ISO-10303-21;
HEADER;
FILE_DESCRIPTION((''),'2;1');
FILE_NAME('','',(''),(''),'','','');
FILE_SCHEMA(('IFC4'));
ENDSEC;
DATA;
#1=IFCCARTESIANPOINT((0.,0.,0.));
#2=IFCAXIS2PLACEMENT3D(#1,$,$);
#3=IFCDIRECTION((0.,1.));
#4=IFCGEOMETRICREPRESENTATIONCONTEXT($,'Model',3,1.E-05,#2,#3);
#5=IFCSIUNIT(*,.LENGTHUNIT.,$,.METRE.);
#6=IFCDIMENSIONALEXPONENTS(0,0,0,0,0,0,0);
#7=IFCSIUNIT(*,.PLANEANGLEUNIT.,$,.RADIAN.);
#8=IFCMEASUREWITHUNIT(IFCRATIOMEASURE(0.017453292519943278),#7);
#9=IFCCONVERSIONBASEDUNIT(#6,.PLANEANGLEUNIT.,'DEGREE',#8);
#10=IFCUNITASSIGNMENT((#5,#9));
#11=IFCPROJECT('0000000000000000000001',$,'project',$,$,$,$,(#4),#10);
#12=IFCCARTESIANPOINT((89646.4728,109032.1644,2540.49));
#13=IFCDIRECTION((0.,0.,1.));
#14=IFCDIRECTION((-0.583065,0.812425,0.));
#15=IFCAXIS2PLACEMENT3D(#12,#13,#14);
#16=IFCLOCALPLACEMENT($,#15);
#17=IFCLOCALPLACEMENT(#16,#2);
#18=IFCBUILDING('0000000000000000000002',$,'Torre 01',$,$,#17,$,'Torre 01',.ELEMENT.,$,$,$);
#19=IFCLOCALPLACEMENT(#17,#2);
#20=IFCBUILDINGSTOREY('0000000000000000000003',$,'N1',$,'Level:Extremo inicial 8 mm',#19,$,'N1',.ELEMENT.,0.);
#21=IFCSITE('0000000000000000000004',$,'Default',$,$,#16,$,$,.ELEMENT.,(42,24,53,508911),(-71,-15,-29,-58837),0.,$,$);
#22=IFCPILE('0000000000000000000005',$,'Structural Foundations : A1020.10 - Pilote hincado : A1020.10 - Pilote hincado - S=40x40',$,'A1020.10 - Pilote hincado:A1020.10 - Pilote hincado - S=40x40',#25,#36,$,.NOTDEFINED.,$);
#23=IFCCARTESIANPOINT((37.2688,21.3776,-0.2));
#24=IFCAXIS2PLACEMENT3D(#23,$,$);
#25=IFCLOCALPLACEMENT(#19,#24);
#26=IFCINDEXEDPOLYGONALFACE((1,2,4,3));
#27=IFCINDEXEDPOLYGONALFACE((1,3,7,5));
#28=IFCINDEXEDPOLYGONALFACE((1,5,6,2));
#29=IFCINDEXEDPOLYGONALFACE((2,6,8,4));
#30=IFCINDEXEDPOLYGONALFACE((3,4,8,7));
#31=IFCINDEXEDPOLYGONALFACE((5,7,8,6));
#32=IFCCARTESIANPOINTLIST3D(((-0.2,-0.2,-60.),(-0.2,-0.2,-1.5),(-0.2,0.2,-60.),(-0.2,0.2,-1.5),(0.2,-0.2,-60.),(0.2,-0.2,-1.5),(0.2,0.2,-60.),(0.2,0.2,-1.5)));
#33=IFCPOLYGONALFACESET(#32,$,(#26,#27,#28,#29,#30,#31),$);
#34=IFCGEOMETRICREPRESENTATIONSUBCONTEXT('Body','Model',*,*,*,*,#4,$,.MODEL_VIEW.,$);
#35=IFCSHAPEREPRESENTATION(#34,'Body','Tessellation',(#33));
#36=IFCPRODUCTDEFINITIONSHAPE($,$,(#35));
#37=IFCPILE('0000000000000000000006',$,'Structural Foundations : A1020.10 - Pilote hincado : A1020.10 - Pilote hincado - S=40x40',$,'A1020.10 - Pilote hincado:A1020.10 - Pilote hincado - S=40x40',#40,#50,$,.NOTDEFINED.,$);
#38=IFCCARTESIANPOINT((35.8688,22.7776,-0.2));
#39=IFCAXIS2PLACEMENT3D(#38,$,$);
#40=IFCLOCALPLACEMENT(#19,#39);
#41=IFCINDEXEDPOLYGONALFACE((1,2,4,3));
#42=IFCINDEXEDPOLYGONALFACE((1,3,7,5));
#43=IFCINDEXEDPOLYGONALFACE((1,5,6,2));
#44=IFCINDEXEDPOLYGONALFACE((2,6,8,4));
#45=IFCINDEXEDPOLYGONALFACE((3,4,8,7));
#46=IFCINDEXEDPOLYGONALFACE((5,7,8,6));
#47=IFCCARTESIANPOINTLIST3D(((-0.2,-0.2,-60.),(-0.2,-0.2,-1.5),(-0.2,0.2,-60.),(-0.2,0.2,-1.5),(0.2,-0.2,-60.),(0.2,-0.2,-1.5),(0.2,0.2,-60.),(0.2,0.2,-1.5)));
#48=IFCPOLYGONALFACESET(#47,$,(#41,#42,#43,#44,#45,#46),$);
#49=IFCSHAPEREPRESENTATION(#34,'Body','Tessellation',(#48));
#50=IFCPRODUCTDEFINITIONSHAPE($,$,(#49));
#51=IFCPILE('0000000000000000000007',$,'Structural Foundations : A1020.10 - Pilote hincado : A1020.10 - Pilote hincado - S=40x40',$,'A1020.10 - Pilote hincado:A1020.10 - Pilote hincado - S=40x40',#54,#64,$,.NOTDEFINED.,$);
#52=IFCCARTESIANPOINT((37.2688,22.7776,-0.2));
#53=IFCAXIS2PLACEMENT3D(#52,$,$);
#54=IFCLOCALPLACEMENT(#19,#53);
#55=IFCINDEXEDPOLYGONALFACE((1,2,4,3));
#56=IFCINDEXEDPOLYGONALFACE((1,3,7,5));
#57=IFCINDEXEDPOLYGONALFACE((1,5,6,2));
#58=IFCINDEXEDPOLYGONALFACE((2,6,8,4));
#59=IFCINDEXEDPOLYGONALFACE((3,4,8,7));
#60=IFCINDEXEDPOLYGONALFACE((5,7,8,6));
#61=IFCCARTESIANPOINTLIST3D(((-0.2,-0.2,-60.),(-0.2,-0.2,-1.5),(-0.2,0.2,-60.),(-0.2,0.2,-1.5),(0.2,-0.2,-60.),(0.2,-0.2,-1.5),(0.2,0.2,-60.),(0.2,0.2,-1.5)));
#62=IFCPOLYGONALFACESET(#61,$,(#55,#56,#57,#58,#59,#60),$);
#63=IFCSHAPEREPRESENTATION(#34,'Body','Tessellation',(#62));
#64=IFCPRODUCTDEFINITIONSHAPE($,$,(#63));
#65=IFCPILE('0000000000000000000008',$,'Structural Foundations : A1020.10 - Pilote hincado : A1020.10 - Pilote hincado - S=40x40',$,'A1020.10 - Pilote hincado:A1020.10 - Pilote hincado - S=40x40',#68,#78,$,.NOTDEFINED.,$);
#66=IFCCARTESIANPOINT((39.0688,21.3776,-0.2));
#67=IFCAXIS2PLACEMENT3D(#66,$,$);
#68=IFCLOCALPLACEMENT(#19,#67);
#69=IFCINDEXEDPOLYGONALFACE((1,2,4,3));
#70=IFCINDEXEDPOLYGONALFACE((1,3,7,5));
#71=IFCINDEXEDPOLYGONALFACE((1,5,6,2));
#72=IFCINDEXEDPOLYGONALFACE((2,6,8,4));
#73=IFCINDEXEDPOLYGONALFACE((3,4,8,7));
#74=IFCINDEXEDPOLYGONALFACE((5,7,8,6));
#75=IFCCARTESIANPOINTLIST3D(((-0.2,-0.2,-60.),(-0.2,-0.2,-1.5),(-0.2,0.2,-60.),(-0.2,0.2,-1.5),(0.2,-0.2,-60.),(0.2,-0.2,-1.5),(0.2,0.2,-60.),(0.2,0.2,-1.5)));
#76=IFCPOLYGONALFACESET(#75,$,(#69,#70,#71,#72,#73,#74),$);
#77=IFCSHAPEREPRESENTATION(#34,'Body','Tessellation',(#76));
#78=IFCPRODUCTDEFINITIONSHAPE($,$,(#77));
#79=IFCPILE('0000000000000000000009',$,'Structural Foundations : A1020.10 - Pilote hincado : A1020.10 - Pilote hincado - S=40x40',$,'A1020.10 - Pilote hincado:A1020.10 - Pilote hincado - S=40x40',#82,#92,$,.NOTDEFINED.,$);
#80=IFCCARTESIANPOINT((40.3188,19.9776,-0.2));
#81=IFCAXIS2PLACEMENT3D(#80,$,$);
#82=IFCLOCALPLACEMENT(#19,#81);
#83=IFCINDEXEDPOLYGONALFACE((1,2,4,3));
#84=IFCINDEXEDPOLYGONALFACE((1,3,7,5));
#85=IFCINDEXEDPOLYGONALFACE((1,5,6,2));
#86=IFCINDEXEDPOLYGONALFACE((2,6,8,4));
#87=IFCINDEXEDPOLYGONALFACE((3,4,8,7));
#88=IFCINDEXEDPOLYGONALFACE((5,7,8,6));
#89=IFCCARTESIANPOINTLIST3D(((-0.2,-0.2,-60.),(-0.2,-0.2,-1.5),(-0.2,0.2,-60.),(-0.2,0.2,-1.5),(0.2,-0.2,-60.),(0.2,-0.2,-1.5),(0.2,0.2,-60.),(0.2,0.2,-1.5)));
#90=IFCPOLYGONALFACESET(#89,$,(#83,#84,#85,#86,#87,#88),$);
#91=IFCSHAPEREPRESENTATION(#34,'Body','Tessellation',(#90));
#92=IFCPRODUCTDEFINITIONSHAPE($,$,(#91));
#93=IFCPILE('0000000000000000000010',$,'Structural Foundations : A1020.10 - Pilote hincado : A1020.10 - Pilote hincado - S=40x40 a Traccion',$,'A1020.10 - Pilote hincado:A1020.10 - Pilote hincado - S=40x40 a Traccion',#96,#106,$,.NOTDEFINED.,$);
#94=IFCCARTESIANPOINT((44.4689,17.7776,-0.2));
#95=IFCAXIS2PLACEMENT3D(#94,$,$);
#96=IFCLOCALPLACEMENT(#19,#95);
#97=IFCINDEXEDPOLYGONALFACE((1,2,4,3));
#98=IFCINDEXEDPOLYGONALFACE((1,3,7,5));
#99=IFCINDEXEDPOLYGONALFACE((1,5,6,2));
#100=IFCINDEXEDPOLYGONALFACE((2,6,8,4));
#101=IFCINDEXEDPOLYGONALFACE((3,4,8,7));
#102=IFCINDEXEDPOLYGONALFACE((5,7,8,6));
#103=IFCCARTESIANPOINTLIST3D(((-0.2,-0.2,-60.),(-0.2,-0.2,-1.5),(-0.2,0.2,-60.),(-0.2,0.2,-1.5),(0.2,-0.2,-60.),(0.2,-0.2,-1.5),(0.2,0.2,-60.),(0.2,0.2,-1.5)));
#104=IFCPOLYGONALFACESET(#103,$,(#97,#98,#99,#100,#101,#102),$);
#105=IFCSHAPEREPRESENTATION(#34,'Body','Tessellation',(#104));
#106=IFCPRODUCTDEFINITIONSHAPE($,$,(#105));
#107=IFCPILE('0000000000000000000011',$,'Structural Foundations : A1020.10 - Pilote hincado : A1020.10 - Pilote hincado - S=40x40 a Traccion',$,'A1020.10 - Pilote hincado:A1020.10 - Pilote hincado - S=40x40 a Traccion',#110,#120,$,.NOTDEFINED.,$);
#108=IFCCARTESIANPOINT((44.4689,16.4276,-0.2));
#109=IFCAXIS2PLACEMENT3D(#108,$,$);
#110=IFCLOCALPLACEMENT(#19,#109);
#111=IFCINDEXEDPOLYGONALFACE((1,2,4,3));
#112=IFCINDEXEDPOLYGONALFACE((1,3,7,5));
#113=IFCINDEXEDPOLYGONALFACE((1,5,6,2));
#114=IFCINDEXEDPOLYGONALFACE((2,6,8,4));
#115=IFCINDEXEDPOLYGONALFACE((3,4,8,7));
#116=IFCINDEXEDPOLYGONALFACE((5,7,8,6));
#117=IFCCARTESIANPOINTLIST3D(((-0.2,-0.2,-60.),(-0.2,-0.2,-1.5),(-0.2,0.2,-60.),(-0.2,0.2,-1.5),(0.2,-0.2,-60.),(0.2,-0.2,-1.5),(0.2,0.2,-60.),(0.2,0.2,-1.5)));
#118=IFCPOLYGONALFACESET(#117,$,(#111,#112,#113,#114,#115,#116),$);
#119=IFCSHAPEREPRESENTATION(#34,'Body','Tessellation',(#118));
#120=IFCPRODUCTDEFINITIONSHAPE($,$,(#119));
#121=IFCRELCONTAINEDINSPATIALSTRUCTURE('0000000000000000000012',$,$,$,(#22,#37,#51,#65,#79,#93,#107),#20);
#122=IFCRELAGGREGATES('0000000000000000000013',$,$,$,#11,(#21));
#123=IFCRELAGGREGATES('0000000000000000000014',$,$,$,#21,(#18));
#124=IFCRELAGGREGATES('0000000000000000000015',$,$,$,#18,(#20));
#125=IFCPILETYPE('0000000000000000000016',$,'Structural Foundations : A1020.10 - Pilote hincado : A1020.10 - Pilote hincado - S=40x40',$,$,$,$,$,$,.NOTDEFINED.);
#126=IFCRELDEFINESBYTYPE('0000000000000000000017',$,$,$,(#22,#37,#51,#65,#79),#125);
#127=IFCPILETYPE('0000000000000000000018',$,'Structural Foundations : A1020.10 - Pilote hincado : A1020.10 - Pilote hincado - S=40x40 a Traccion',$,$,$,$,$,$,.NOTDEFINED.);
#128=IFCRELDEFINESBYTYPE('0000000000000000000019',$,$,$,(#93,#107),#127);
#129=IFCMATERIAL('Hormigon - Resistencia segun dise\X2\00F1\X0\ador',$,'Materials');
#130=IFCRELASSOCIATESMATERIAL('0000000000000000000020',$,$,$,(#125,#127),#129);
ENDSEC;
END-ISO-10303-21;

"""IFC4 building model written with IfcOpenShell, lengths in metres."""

from ifc_helpers import new_model, entity, si_unit, converted_unit, direction, frame, origin, origin_2d_with_axis, place, context, subcontext, project, spatial, polyline, segment, composite_curve, rectangle, outline, extrude, source, transform, mapped, material, material_profile, profile_set, type_object, type_shapes, element, save


model = new_model("IFC4")

# Units and contexts
model_context = context("Model", 3, precision=1e-05, world=origin(), true_north=direction((0.0, 1.0)))
body_context = subcontext(model_context, "Body", "Model", "MODEL_VIEW")
ifc_project = project(units=[si_unit("LENGTHUNIT", "METRE"), converted_unit("PLANEANGLEUNIT", "DEGREE", entity("IfcRatioMeasure", 0.017453292519943278), si_unit("PLANEANGLEUNIT", "RADIAN"), dimensions=[0, 0, 0, 0, 0, 0, 0])], contexts=[model_context])

# Site, building, storey
site_placement = place(None, frame((89646.4728, 109032.1644, 2540.49), z_axis=(0.0, 0.0, 1.0), x_axis=(-0.583065, 0.812425, 0.0)))
site = spatial("IfcSite", under=ifc_project, at=site_placement, Name="Default", CompositionType="ELEMENT", RefLatitude=(42, 24, 53, 508911), RefLongitude=(-71, -15, -29, -58837), RefElevation=0.0)
building_placement = place(site_placement, origin())
building = spatial("IfcBuilding", under=site, at=building_placement, Name="Torre 01", LongName="Torre 01", CompositionType="ELEMENT")
storey_placement = place(building_placement, origin())
storey = spatial("IfcBuildingStorey", under=building, at=storey_placement, Name="N1", ObjectType="Level:Extremo inicial 8 mm", LongName="N1", CompositionType="ELEMENT", Elevation=0.0)

# Piles
ifc_material_1 = material(Name="Hormigon - Resistencia segun diseñador", Category="Materials")
ifc_material_profile_1 = material_profile(ifc_material_1, outline(composite_curve([segment(polyline([(0.2, -0.2, -60.0), (-0.2, -0.2, -60.0)]), True, "CONTINUOUS"), segment(polyline([(-0.2, -0.2, -60.0), (-0.2, 0.2, -60.0)]), True, "CONTINUOUS"), segment(polyline([(-0.2, 0.2, -60.0), (0.2, 0.2, -60.0)]), True, "CONTINUOUS"), segment(polyline([(0.2, 0.2, -60.0), (0.2, -0.2, -60.0)]), True, "CONTINUOUS")], self_intersect=False), kind="CURVE"), Name="A1020.10 - Pilote hincado - S=40x40")
ifc_profile_set_1 = profile_set([ifc_material_profile_1], Name="A1020.10 - Pilote hincado - S=40x40")
pile_type_1 = type_object("IfcPileType", Name="Structural Foundations : A1020.10 - Pilote hincado : A1020.10 - Pilote hincado - S=40x40", PredefinedType="NOTDEFINED", material=ifc_profile_set_1)
shared_shape_1 = source(origin(), body_context, "Body", "SweptSolid", [
    extrude(rectangle(XDim=0.4, YDim=0.4, at=origin_2d_with_axis()), frame((0.0, 0.0, -60.0), z_axis=(0.0, 0.0, 1.0), x_axis=(0.0, -1.0, 0.0)), (0.0, 0.0, 1.0), 58.5),
])
type_shapes(pile_type_1, [shared_shape_1])
for number, where, name in (
    (1, (37.2688, 21.3776, -0.2), "Structural Foundations : A1020.10 - Pilote hincado : A1020.10 - Pilote hincado - S=40x40"),
    (2, (35.8688, 22.7776, -0.2), "Structural Foundations : A1020.10 - Pilote hincado : A1020.10 - Pilote hincado - S=40x40"),
    (3, (37.2688, 22.7776, -0.2), "Structural Foundations : A1020.10 - Pilote hincado : A1020.10 - Pilote hincado - S=40x40"),
    (4, (39.0688, 21.3776, -0.2), "Structural Foundations : A1020.10 - Pilote hincado : A1020.10 - Pilote hincado - S=40x40"),
    (5, (40.3188, 19.9776, -0.2), "Structural Foundations : A1020.10 - Pilote hincado : A1020.10 - Pilote hincado - S=40x40"),
):
    element("IfcPile", number, at=place(storey_placement, frame(where)), inside=storey, type_object=pile_type_1, Name=name, ObjectType="A1020.10 - Pilote hincado:A1020.10 - Pilote hincado - S=40x40", PredefinedType="NOTDEFINED", context=body_context, shape_type="MappedRepresentation", body=[
        mapped(shared_shape_1, transform((0.0, 0.0, 0.0), scale=1.0)),
    ])
ifc_material_profile_2 = material_profile(ifc_material_1, outline(composite_curve([segment(polyline([(0.2, -0.2, -60.0), (-0.2, -0.2, -60.0)]), True, "CONTINUOUS"), segment(polyline([(-0.2, -0.2, -60.0), (-0.2, 0.2, -60.0)]), True, "CONTINUOUS"), segment(polyline([(-0.2, 0.2, -60.0), (0.2, 0.2, -60.0)]), True, "CONTINUOUS"), segment(polyline([(0.2, 0.2, -60.0), (0.2, -0.2, -60.0)]), True, "CONTINUOUS")], self_intersect=False), kind="CURVE"), Name="A1020.10 - Pilote hincado - S=40x40 a Traccion")
ifc_profile_set_2 = profile_set([ifc_material_profile_2], Name="A1020.10 - Pilote hincado - S=40x40 a Traccion")
pile_type_2 = type_object("IfcPileType", Name="Structural Foundations : A1020.10 - Pilote hincado : A1020.10 - Pilote hincado - S=40x40 a Traccion", PredefinedType="NOTDEFINED", material=ifc_profile_set_2)
shared_shape_2 = source(origin(), body_context, "Body", "SweptSolid", [
    extrude(rectangle(XDim=0.4, YDim=0.4, at=origin_2d_with_axis()), frame((0.0, 0.0, -60.0), z_axis=(0.0, 0.0, 1.0), x_axis=(0.0, -1.0, 0.0)), (0.0, 0.0, 1.0), 58.5),
])
type_shapes(pile_type_2, [shared_shape_2])
for number, where, name in (
    (6, (44.4689, 17.7776, -0.2), "Structural Foundations : A1020.10 - Pilote hincado : A1020.10 - Pilote hincado - S=40x40 a Traccion"),
    (7, (44.4689, 16.4276, -0.2), "Structural Foundations : A1020.10 - Pilote hincado : A1020.10 - Pilote hincado - S=40x40 a Traccion"),
):
    element("IfcPile", number, at=place(storey_placement, frame(where)), inside=storey, type_object=pile_type_2, Name=name, ObjectType="A1020.10 - Pilote hincado:A1020.10 - Pilote hincado - S=40x40 a Traccion", PredefinedType="NOTDEFINED", context=body_context, shape_type="MappedRepresentation", body=[
        mapped(shared_shape_2, transform((0.0, 0.0, 0.0), scale=1.0)),
    ])

save(model, "model.ifc")
